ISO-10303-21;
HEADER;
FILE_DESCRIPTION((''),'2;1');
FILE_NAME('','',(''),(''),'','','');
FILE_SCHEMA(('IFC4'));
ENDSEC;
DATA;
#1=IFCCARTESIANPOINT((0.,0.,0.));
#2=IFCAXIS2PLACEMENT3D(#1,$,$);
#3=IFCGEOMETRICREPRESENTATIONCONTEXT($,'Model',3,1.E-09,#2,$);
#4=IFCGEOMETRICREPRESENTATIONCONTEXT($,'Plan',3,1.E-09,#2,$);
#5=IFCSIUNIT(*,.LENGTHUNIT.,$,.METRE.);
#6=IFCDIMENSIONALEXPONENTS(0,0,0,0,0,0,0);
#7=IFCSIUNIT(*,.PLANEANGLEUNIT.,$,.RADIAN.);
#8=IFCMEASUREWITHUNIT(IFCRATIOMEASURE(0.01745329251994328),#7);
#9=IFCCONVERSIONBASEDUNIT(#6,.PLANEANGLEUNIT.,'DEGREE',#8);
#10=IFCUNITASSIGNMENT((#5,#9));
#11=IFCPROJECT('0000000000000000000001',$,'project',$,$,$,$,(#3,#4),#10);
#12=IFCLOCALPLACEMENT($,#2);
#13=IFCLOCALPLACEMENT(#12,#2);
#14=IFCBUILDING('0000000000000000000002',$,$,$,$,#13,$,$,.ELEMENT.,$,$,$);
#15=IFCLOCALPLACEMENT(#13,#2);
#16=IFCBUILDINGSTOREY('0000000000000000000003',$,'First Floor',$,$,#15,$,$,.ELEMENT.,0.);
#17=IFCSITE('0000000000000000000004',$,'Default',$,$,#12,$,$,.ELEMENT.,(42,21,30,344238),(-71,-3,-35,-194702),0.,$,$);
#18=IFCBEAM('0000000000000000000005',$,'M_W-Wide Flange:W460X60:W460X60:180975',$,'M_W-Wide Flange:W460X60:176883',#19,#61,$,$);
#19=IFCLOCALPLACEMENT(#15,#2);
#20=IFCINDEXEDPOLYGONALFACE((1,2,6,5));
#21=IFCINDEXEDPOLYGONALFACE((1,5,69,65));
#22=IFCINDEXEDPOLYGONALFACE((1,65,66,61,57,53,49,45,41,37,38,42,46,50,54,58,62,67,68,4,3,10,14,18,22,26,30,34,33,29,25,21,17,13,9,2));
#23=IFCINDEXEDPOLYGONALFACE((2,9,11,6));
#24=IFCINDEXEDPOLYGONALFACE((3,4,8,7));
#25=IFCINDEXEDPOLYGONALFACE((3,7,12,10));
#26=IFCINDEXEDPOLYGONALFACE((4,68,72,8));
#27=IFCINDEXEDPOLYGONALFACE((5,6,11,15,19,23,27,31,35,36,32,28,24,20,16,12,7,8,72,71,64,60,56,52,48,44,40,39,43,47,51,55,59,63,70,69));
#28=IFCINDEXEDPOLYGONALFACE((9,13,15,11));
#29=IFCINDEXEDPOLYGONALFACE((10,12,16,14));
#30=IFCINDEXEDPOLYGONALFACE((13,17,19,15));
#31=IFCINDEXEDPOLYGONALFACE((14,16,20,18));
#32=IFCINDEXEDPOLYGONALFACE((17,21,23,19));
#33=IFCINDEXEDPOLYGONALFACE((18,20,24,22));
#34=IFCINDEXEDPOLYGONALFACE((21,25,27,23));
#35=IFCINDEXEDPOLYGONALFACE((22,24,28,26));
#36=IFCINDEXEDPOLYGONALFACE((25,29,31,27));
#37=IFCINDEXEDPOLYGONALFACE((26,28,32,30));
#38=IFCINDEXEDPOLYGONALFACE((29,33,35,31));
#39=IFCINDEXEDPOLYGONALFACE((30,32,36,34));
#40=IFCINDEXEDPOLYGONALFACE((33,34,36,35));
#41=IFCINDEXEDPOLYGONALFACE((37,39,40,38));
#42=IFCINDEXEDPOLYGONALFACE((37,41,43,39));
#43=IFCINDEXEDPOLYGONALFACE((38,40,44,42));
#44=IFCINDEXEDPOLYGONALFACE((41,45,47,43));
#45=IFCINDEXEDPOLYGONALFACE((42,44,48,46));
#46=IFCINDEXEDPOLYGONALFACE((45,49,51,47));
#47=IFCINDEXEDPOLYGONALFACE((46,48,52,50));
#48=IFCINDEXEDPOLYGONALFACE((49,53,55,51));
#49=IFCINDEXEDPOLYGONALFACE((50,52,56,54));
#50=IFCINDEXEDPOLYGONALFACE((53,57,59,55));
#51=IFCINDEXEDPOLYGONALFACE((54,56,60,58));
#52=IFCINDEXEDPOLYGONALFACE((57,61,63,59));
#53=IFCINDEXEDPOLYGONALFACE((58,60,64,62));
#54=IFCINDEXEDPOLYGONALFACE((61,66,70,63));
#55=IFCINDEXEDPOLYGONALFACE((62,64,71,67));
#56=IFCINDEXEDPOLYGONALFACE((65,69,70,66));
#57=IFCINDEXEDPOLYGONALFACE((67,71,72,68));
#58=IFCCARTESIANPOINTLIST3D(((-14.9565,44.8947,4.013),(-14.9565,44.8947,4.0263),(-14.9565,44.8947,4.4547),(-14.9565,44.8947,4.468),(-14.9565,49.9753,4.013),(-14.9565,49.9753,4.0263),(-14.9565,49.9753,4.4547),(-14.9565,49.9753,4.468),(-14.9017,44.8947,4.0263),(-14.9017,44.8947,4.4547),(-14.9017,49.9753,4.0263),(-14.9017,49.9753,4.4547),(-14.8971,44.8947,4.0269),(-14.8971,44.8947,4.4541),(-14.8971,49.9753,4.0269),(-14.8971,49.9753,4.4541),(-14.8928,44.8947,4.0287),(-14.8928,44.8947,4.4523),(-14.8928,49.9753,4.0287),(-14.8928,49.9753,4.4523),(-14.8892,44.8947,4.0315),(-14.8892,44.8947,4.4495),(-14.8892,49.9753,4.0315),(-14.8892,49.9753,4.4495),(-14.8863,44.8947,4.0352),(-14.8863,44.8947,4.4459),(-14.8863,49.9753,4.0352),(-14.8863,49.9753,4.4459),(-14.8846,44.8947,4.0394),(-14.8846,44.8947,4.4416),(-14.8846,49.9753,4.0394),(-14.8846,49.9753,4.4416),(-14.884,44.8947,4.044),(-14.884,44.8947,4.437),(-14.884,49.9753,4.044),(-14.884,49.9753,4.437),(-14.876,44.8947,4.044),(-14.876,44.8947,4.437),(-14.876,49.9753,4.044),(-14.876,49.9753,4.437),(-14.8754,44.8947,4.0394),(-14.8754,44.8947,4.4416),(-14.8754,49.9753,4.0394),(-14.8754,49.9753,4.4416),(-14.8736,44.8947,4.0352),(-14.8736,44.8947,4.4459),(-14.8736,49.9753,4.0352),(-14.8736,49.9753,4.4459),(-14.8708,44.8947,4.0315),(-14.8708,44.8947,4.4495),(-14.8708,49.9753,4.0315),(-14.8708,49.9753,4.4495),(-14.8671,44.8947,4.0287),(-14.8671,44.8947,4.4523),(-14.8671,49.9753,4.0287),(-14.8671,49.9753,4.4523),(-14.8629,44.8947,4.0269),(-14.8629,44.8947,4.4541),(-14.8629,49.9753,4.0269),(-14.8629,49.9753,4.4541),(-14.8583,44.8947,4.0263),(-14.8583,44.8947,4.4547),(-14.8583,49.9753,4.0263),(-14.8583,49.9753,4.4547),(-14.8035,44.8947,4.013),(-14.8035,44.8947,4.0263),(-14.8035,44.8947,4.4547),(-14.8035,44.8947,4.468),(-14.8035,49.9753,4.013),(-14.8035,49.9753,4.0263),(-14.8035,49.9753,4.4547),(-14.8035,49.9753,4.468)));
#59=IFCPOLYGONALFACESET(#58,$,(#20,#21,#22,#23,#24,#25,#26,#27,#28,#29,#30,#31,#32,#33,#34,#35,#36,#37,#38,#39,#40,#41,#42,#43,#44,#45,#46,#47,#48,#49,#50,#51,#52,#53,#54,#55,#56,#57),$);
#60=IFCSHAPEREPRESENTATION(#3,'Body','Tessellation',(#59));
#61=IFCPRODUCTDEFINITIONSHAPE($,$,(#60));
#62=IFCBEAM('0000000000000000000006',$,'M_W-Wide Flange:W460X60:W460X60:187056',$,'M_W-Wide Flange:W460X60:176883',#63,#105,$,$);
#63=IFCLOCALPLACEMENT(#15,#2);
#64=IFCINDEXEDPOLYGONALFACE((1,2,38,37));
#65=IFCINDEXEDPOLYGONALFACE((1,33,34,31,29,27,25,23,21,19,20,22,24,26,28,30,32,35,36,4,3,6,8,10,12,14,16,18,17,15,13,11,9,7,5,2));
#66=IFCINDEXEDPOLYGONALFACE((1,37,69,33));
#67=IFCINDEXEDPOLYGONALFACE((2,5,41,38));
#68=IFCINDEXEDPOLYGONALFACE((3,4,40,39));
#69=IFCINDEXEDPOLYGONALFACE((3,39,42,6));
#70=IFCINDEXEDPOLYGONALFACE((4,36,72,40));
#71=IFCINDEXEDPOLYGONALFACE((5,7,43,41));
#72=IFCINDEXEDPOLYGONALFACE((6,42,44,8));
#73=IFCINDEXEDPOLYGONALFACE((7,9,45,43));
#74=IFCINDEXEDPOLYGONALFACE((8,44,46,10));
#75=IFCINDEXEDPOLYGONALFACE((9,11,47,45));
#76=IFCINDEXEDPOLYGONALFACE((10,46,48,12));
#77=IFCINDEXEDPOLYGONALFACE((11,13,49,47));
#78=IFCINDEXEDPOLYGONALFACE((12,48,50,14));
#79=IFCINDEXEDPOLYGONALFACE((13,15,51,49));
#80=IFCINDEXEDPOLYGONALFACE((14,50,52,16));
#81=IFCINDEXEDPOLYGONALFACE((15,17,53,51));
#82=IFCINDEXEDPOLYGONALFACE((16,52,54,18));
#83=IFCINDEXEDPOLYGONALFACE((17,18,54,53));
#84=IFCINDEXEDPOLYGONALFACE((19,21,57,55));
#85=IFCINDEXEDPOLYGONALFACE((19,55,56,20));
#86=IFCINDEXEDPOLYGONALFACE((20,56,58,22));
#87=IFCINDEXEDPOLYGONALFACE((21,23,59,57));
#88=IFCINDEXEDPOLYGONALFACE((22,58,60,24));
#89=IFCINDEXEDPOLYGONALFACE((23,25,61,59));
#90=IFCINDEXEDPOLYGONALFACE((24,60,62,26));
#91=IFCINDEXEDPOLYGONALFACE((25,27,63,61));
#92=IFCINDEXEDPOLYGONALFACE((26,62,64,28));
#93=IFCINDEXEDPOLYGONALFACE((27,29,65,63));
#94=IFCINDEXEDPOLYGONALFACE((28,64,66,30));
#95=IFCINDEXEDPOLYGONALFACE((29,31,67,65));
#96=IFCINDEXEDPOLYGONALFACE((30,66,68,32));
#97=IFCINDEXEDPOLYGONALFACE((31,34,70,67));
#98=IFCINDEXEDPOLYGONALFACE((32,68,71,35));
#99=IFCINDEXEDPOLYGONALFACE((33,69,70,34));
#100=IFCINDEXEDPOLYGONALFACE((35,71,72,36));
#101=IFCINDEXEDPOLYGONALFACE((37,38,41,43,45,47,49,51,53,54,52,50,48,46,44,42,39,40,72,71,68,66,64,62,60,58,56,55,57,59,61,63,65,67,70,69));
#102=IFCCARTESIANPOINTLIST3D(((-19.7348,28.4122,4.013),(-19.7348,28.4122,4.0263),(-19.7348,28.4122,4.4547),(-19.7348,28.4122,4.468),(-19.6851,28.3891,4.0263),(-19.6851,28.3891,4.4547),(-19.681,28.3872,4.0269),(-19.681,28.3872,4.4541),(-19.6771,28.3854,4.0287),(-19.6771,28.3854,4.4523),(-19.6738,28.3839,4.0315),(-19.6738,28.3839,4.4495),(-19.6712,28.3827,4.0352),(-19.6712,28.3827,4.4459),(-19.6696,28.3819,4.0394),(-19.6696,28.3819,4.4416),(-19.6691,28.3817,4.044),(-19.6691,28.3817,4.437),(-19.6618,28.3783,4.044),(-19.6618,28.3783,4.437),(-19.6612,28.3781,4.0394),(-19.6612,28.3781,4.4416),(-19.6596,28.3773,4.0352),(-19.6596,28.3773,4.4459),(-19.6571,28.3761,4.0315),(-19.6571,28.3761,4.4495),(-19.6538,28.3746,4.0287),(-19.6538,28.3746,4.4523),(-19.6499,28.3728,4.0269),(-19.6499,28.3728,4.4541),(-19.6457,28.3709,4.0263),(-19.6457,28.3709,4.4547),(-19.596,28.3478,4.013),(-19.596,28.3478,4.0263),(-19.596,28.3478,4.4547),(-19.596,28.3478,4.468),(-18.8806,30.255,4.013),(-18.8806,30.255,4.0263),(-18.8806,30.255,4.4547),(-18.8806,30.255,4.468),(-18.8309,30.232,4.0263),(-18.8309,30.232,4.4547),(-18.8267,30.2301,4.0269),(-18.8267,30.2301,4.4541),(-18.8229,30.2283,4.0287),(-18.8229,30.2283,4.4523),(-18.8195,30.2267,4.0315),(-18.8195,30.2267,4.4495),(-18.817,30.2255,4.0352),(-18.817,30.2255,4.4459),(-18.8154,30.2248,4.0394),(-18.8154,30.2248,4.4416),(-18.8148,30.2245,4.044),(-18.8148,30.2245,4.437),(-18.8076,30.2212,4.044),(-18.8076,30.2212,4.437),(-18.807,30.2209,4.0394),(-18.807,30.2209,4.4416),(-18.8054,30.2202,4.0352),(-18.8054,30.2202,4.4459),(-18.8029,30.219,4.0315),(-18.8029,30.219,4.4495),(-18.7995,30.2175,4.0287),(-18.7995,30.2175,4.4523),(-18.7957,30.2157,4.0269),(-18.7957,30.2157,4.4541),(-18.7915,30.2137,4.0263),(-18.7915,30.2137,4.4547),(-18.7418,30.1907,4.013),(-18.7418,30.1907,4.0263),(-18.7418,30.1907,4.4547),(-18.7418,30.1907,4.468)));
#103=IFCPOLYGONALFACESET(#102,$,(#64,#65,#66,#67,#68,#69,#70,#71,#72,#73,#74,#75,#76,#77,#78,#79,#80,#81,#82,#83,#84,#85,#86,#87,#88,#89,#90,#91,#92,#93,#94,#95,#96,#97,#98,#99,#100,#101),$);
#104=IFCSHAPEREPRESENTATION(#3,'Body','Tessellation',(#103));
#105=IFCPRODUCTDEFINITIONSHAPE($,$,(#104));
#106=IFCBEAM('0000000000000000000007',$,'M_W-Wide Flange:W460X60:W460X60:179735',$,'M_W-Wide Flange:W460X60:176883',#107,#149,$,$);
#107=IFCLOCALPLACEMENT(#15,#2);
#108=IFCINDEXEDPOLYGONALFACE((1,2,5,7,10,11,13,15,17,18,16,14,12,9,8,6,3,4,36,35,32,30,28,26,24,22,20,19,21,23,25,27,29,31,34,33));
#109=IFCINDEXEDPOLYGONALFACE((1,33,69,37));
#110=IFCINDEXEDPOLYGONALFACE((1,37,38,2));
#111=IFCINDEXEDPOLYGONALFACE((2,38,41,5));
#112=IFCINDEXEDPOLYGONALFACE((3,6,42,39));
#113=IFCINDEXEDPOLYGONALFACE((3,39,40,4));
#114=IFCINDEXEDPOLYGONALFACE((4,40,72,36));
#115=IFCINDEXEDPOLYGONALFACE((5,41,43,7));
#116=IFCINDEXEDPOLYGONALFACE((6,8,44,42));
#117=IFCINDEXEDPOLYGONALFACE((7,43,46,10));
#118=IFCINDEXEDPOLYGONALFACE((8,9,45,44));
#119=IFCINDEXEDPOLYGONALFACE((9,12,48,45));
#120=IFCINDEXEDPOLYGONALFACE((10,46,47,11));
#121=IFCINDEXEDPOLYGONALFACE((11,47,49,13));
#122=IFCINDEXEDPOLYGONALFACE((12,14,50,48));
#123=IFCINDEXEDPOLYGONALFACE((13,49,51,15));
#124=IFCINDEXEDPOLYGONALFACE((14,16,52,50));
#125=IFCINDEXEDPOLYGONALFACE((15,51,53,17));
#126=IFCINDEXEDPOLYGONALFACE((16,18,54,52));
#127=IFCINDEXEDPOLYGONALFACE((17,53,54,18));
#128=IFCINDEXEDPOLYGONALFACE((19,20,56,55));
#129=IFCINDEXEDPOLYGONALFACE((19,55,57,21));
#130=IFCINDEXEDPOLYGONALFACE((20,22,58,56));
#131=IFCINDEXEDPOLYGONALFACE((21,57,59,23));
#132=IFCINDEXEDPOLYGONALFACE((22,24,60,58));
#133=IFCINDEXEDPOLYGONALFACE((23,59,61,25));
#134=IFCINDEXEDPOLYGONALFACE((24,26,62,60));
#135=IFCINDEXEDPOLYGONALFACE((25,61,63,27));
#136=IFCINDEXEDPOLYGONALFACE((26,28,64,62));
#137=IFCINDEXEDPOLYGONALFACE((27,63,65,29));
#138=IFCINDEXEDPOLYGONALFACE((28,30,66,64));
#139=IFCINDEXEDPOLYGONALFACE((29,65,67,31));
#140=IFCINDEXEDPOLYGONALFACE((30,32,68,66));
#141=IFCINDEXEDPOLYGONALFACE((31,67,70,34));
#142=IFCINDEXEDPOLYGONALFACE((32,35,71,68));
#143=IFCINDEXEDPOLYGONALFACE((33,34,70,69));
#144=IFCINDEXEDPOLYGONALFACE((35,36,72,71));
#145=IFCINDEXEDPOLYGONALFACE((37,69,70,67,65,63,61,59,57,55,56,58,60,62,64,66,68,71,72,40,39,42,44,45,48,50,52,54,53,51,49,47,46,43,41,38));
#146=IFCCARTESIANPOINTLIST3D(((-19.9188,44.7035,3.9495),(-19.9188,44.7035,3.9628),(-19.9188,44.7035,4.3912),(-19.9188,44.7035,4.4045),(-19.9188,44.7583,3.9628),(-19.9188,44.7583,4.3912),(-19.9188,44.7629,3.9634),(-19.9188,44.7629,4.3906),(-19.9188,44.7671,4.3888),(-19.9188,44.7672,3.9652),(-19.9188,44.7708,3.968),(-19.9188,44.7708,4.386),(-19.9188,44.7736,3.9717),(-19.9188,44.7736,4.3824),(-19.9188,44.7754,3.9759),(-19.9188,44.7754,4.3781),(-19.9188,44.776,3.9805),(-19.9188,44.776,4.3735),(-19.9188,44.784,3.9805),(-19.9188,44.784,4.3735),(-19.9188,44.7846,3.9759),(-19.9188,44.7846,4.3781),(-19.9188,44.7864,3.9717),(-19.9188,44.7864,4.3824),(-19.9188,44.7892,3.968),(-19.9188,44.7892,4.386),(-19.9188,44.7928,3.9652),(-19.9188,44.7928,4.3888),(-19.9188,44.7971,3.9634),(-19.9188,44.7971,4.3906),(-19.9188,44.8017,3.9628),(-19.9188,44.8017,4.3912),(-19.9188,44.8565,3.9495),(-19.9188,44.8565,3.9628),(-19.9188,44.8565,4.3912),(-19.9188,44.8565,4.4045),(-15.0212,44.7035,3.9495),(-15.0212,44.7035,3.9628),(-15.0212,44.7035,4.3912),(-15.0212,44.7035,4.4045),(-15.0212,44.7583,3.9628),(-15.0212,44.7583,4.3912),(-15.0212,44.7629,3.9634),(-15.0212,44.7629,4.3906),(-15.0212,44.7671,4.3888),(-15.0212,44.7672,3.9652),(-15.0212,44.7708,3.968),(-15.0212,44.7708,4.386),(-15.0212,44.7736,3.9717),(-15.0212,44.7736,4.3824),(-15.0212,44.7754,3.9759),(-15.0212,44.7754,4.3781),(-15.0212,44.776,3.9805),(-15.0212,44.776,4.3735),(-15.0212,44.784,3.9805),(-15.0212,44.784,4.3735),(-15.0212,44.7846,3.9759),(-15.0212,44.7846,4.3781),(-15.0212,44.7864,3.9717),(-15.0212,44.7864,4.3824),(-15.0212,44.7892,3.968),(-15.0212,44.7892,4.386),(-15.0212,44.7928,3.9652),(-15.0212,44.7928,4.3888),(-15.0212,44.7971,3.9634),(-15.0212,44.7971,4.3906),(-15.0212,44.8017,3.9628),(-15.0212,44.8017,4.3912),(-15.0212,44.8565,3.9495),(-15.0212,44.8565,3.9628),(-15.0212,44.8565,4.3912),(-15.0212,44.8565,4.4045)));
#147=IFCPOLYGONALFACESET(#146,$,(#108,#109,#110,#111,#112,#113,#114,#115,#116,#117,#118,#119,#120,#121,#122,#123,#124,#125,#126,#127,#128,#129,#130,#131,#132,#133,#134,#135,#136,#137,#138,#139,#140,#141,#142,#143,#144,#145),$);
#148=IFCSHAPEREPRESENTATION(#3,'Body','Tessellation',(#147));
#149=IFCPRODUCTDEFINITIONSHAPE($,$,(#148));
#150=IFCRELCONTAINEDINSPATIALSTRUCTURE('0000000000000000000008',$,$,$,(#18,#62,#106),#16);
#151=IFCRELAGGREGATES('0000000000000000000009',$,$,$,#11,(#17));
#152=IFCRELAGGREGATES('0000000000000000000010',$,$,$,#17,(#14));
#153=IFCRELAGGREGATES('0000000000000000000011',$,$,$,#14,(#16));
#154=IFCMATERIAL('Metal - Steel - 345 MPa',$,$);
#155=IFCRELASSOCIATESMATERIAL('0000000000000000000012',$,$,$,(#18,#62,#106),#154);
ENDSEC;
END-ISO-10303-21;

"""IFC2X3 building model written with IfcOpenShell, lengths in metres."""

from ifc_helpers import new_model, entity, si_unit, converted_unit, frame, frame_2d, origin, place, context, project, spatial, polyline, circle_curve, parameter, trimmed, segment, composite_curve, outline, extrude, material, element, save


model = new_model("IFC2X3")

# Units and contexts
model_context = context("Model", 3, precision=1e-09, world=origin())
plan_context = context("Plan", 3, precision=1e-09, world=origin())
ifc_project = project(units=[si_unit("LENGTHUNIT", "METRE"), converted_unit("PLANEANGLEUNIT", "DEGREE", entity("IfcRatioMeasure", 0.01745329251994328), si_unit("PLANEANGLEUNIT", "RADIAN"), dimensions=[0, 0, 0, 0, 0, 0, 0])], contexts=[model_context, plan_context])

# Site, building, storey
site_placement = place(None, origin())
site = spatial("IfcSite", under=ifc_project, at=site_placement, Name="Default", CompositionType="ELEMENT", RefLatitude=(42, 21, 30, 344238), RefLongitude=(-71, -3, -35, -194702), RefElevation=0.0)
building_placement = place(site_placement, origin())
building = spatial("IfcBuilding", under=site, at=building_placement, CompositionType="ELEMENT")
storey_placement = place(building_placement, origin())
storey = spatial("IfcBuildingStorey", under=building, at=storey_placement, Name="First Floor", CompositionType="ELEMENT", Elevation=0.0)

# Shared definitions
ifc_material = material(Name="Metal - Steel - 345 MPa")

# Beams
beam_1_placement = place(storey_placement, frame((-14.88, 50.0926, 4.468), z_axis=(0.0, 0.0, 1.0), x_axis=(-1.0, 0.0, 0.0)))
element("IfcBeam", 1, at=beam_1_placement, inside=storey, material=ifc_material, Name="M_W-Wide Flange:W460X60:W460X60:180975", ObjectType="M_W-Wide Flange:W460X60:176883", context=model_context, shape_type="SweptSolid", body=[
    extrude(outline(composite_curve([segment(polyline([(0.2142, -0.0765), (0.2275, -0.0765)]), True, "CONTINUOUS"), segment(polyline([(0.2275, -0.0765), (0.2275, 0.0765)]), True, "CONTINUOUS"), segment(polyline([(0.2275, 0.0765), (0.2142, 0.0765)]), True, "CONTINUOUS"), segment(polyline([(0.2142, 0.0765), (0.2142, 0.0217)]), True, "CONTINUOUS"), segment(trimmed(circle_curve(frame_2d((0.1965, 0.0217), x_axis=(1.0, 0.0)), 0.0177), [parameter(270.0)], [parameter(360.0)], True, "PARAMETER"), False, "CONTINUOUS"), segment(polyline([(0.1965, 0.004), (-0.1965, 0.004)]), True, "CONTINUOUS"), segment(trimmed(circle_curve(frame_2d((-0.1965, 0.0217), x_axis=(0.0, -1.0)), 0.0177), [parameter(270.0)], [parameter(360.0)], True, "PARAMETER"), False, "CONTINUOUS"), segment(polyline([(-0.2142, 0.0217), (-0.2142, 0.0765)]), True, "CONTINUOUS"), segment(polyline([(-0.2142, 0.0765), (-0.2275, 0.0765)]), True, "CONTINUOUS"), segment(polyline([(-0.2275, 0.0765), (-0.2275, -0.0765)]), True, "CONTINUOUS"), segment(polyline([(-0.2275, -0.0765), (-0.2142, -0.0765)]), True, "CONTINUOUS"), segment(polyline([(-0.2142, -0.0765), (-0.2142, -0.0217)]), True, "CONTINUOUS"), segment(trimmed(circle_curve(frame_2d((-0.1965, -0.0217), x_axis=(-1.0, 0.0)), 0.0177), [parameter(270.0)], [parameter(360.0)], True, "PARAMETER"), False, "CONTINUOUS"), segment(polyline([(-0.1965, -0.004), (0.1965, -0.004)]), True, "CONTINUOUS"), segment(trimmed(circle_curve(frame_2d((0.1965, -0.0217), x_axis=(0.0, 1.0)), 0.0177), [parameter(270.0)], [parameter(0.0)], True, "PARAMETER"), False, "CONTINUOUS"), segment(polyline([(0.2142, -0.0217), (0.2142, -0.0765)]), True, "CONTINUOUS")], self_intersect=False)), frame((0.0, 5.1979, -0.2275), z_axis=(0.0, -1.0, 0.0), x_axis=(0.0, 0.0, -1.0)), (0.0, 0.0, 1.0), 5.0806),
])
beam_2_placement = place(storey_placement, frame((-18.7224, 30.4144, 4.468), z_axis=(0.0, 0.0, 1.0), x_axis=(-0.907271, 0.420546, 0.0)))
element("IfcBeam", 2, at=beam_2_placement, inside=storey, material=ifc_material, Name="M_W-Wide Flange:W460X60:W460X60:187056", ObjectType="M_W-Wide Flange:W460X60:176883", context=model_context, shape_type="SweptSolid", body=[
    extrude(outline(composite_curve([segment(polyline([(0.2142, -0.0765), (0.2275, -0.0765)]), True, "CONTINUOUS"), segment(polyline([(0.2275, -0.0765), (0.2275, 0.0765)]), True, "CONTINUOUS"), segment(polyline([(0.2275, 0.0765), (0.2142, 0.0765)]), True, "CONTINUOUS"), segment(polyline([(0.2142, 0.0765), (0.2142, 0.0217)]), True, "CONTINUOUS"), segment(trimmed(circle_curve(frame_2d((0.1965, 0.0217), x_axis=(0.0, 1.0)), 0.0177), [parameter(180.0)], [parameter(270.0)], True, "PARAMETER"), False, "CONTINUOUS"), segment(polyline([(0.1965, 0.004), (-0.1965, 0.004)]), True, "CONTINUOUS"), segment(trimmed(circle_curve(frame_2d((-0.1965, 0.0217), x_axis=(0.0, 1.0)), 0.0177), [parameter(90.0)], [parameter(180.0)], True, "PARAMETER"), False, "CONTINUOUS"), segment(polyline([(-0.2142, 0.0217), (-0.2142, 0.0765)]), True, "CONTINUOUS"), segment(polyline([(-0.2142, 0.0765), (-0.2275, 0.0765)]), True, "CONTINUOUS"), segment(polyline([(-0.2275, 0.0765), (-0.2275, -0.0765)]), True, "CONTINUOUS"), segment(polyline([(-0.2275, -0.0765), (-0.2142, -0.0765)]), True, "CONTINUOUS"), segment(polyline([(-0.2142, -0.0765), (-0.2142, -0.0217)]), True, "CONTINUOUS"), segment(trimmed(circle_curve(frame_2d((-0.1965, -0.0217), x_axis=(0.0, 1.0)), 0.0177), [parameter(360.0)], [parameter(90.0)], True, "PARAMETER"), False, "CONTINUOUS"), segment(polyline([(-0.1965, -0.004), (0.1965, -0.004)]), True, "CONTINUOUS"), segment(trimmed(circle_curve(frame_2d((0.1965, -0.0217), x_axis=(0.0, 1.0)), 0.0177), [parameter(270.0)], [parameter(0.0)], True, "PARAMETER"), False, "CONTINUOUS"), segment(polyline([(0.2142, -0.0217), (0.2142, -0.0765)]), True, "CONTINUOUS")], self_intersect=False)), frame((0.0, 2.2423, -0.2275), z_axis=(0.0, -1.0, 0.0), x_axis=(0.0, 0.0, -1.0)), (0.0, 0.0, 1.0), 2.0312),
])
beam_3_placement = place(storey_placement, frame((-20.0626, 44.78, 4.4045), z_axis=(0.0, 0.0, 1.0), x_axis=(0.0, -1.0, 0.0)))
element("IfcBeam", 3, at=beam_3_placement, inside=storey, material=ifc_material, Name="M_W-Wide Flange:W460X60:W460X60:179735", ObjectType="M_W-Wide Flange:W460X60:176883", context=model_context, shape_type="SweptSolid", body=[
    extrude(outline(composite_curve([segment(polyline([(-0.0765, -0.2142), (-0.0765, -0.2275)]), True, "CONTINUOUS"), segment(polyline([(-0.0765, -0.2275), (0.0765, -0.2275)]), True, "CONTINUOUS"), segment(polyline([(0.0765, -0.2275), (0.0765, -0.2142)]), True, "CONTINUOUS"), segment(polyline([(0.0765, -0.2142), (0.0217, -0.2142)]), True, "CONTINUOUS"), segment(trimmed(circle_curve(frame_2d((0.0217, -0.1965), x_axis=(0.0, -1.0)), 0.0177), [parameter(270.0)], [parameter(360.0)], True, "PARAMETER"), False, "CONTINUOUS"), segment(polyline([(0.004, -0.1965), (0.004, 0.1965)]), True, "CONTINUOUS"), segment(trimmed(circle_curve(frame_2d((0.0217, 0.1965), x_axis=(-1.0, 0.0)), 0.0177), [parameter(270.0)], [parameter(360.0)], True, "PARAMETER"), False, "CONTINUOUS"), segment(polyline([(0.0217, 0.2142), (0.0765, 0.2142)]), True, "CONTINUOUS"), segment(polyline([(0.0765, 0.2142), (0.0765, 0.2275)]), True, "CONTINUOUS"), segment(polyline([(0.0765, 0.2275), (-0.0765, 0.2275)]), True, "CONTINUOUS"), segment(polyline([(-0.0765, 0.2275), (-0.0765, 0.2142)]), True, "CONTINUOUS"), segment(polyline([(-0.0765, 0.2142), (-0.0217, 0.2142)]), True, "CONTINUOUS"), segment(trimmed(circle_curve(frame_2d((-0.0217, 0.1965), x_axis=(0.0, 1.0)), 0.0177), [parameter(270.0)], [parameter(360.0)], True, "PARAMETER"), False, "CONTINUOUS"), segment(polyline([(-0.004, 0.1965), (-0.004, -0.1965)]), True, "CONTINUOUS"), segment(trimmed(circle_curve(frame_2d((-0.0217, -0.1965), x_axis=(1.0, 0.0)), 0.0177), [parameter(270.0)], [parameter(0.0)], True, "PARAMETER"), False, "CONTINUOUS"), segment(polyline([(-0.0217, -0.2142), (-0.0765, -0.2142)]), True, "CONTINUOUS")], self_intersect=False)), frame((0.0, 0.1438, -0.2275), z_axis=(0.0, -1.0, 0.0), x_axis=(1.0, 0.0, 0.0)), (0.0, 0.0, -1.0), 4.8976),
])

save(model, "model.ifc")
